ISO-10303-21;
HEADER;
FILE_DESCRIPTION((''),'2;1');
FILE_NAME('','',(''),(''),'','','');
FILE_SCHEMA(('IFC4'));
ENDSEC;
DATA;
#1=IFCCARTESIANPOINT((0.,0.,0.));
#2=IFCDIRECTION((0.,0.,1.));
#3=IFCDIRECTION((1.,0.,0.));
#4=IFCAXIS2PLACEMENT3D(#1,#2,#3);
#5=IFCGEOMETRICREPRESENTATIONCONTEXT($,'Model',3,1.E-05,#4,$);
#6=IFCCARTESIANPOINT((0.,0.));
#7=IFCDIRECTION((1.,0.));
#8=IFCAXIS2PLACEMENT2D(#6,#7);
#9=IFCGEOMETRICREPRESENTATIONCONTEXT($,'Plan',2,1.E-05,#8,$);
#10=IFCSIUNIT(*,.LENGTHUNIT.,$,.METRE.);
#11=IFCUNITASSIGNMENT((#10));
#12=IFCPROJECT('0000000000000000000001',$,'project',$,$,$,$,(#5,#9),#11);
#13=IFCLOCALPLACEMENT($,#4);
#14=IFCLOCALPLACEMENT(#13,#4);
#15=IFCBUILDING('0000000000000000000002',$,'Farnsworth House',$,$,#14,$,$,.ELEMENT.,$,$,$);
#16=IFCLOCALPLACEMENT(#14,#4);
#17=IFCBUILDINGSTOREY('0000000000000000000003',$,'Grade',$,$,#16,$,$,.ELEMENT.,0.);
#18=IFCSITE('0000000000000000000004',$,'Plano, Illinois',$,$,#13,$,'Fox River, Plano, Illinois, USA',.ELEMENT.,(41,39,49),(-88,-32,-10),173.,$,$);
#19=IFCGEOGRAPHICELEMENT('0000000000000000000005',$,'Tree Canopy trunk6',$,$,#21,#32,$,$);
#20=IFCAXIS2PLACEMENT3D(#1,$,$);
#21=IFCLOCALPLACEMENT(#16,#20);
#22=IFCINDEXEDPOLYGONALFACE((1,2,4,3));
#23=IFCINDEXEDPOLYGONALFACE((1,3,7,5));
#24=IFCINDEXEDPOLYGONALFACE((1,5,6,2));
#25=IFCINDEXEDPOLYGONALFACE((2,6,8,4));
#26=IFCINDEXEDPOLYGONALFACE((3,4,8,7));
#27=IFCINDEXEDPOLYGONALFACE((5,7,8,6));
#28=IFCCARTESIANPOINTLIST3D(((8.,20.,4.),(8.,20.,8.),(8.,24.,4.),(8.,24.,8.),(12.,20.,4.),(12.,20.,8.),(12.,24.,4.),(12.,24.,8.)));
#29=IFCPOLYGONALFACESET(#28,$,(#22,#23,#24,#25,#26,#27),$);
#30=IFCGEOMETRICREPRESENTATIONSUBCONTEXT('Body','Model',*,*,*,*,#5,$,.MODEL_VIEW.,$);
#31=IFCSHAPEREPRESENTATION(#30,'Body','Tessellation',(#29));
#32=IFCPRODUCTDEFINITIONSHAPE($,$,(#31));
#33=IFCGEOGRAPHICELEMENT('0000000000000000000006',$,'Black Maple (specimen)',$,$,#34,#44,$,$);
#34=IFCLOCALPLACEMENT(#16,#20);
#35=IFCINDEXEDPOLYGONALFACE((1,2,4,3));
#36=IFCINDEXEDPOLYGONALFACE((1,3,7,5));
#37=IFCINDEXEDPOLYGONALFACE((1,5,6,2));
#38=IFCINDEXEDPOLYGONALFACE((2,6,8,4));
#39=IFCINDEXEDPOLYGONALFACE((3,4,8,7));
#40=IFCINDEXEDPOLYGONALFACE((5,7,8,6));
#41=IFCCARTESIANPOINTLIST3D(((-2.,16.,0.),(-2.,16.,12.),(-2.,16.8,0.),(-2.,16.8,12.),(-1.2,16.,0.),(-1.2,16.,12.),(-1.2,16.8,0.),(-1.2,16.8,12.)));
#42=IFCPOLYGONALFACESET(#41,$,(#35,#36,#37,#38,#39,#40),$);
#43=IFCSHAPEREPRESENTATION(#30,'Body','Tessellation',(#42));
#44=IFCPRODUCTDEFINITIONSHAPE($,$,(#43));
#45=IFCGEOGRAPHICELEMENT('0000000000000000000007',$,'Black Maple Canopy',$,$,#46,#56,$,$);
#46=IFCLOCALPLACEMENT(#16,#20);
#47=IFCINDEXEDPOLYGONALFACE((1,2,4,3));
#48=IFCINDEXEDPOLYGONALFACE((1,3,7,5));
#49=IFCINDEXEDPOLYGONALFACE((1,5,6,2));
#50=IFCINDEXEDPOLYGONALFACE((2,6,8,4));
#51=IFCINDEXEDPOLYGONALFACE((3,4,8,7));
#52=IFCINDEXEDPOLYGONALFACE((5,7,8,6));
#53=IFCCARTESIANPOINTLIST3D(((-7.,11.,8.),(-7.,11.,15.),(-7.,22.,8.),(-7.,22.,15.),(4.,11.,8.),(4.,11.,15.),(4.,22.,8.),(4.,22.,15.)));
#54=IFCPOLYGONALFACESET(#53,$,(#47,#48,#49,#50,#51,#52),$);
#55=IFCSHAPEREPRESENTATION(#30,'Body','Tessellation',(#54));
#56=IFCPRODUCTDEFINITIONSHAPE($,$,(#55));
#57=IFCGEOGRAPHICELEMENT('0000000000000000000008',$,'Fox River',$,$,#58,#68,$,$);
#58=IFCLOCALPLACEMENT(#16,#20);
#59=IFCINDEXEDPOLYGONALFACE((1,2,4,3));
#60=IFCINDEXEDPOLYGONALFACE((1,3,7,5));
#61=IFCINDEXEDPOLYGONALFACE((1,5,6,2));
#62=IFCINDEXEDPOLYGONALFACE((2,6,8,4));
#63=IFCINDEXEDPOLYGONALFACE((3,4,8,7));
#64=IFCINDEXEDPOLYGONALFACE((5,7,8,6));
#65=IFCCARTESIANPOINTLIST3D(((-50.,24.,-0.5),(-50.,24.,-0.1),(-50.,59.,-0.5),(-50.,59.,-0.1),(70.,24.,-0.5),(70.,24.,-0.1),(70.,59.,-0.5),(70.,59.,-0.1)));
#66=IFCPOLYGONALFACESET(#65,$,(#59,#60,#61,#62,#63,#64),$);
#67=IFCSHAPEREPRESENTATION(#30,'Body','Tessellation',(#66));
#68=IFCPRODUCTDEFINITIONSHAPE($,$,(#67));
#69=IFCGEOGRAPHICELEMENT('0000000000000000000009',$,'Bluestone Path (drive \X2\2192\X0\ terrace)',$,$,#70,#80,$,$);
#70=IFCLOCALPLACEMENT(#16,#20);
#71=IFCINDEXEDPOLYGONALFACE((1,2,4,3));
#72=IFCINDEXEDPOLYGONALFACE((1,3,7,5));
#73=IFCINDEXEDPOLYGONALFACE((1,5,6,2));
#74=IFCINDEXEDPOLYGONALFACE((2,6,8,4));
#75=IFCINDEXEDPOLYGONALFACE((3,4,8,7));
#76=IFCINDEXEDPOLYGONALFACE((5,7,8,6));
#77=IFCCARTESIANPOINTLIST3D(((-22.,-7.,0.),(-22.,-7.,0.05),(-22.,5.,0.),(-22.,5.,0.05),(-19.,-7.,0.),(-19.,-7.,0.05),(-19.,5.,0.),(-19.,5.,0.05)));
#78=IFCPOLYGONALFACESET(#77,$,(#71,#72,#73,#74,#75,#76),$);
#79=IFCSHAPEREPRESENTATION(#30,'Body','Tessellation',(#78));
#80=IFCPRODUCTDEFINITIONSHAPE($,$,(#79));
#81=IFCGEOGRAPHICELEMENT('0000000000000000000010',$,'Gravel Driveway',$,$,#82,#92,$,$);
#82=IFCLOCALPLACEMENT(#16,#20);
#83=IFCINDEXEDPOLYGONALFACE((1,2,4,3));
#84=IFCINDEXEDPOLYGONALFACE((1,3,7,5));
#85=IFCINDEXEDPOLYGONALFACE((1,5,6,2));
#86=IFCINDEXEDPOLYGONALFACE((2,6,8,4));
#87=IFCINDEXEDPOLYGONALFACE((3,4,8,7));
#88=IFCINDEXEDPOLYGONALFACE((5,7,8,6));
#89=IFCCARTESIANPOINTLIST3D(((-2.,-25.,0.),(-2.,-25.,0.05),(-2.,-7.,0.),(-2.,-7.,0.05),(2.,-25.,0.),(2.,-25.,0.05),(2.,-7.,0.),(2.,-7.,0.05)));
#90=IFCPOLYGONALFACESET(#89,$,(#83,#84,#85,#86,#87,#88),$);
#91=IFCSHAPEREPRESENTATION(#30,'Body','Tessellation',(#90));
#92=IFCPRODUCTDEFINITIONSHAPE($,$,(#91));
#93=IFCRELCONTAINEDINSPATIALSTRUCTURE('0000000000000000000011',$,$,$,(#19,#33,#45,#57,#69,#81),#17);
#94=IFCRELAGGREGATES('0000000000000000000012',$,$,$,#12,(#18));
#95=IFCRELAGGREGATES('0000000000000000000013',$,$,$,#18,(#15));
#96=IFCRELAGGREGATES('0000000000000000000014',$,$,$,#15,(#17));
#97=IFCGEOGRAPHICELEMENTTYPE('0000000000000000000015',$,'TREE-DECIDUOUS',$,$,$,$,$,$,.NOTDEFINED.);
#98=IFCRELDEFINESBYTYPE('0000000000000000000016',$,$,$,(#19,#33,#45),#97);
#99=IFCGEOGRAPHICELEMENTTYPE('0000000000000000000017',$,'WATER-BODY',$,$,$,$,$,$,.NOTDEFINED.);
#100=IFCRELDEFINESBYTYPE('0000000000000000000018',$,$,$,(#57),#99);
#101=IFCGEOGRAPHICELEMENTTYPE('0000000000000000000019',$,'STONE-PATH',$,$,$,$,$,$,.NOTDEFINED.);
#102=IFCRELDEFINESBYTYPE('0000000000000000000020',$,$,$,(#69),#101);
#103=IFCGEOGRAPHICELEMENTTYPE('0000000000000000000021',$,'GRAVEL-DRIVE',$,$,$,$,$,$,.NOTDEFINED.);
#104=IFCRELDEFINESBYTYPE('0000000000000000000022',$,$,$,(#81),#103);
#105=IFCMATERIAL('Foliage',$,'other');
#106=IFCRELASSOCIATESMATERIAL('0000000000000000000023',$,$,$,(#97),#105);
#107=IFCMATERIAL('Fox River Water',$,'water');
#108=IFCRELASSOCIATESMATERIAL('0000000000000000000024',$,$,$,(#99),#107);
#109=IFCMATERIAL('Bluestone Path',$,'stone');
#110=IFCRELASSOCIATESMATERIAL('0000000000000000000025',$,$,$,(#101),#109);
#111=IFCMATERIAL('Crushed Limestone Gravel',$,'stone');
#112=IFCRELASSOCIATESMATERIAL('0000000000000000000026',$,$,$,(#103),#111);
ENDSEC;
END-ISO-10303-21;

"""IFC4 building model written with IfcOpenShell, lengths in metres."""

from ifc_helpers import new_model, si_unit, frame, origin_with_axes, origin_2d_with_axis, place, context, subcontext, project, spatial, rectangle, extrude, material, type_object, element, save


model = new_model("IFC4")

# Units and contexts
model_context = context("Model", 3, precision=1e-05, world=origin_with_axes())
plan_context = context("Plan", 2, precision=1e-05, world=origin_2d_with_axis())
body_context = subcontext(model_context, "Body", "Model", "MODEL_VIEW")
ifc_project = project(units=[si_unit("LENGTHUNIT", "METRE")], contexts=[model_context, plan_context])

# Site, building, storey
site_placement = place(None, origin_with_axes())
site = spatial("IfcSite", under=ifc_project, at=site_placement, Name="Plano, Illinois", LongName="Fox River, Plano, Illinois, USA", CompositionType="ELEMENT", RefLatitude=(41, 39, 49), RefLongitude=(-88, -32, -10), RefElevation=173.0)
building_placement = place(site_placement, origin_with_axes())
building = spatial("IfcBuilding", under=site, at=building_placement, Name="Farnsworth House", CompositionType="ELEMENT")
storey_placement = place(building_placement, origin_with_axes())
storey = spatial("IfcBuildingStorey", under=building, at=storey_placement, Name="Grade", CompositionType="ELEMENT", Elevation=0.0)

# Geographic elements
ifc_material_1 = material(Name="Foliage", Category="other")
geographic_element_type_1 = type_object("IfcGeographicElementType", Name="TREE-DECIDUOUS", PredefinedType="NOTDEFINED", material=ifc_material_1)
geographic_element_1_placement = place(storey_placement, frame((8.0, 20.0, 4.0), z_axis=(0.0, 0.0, 1.0), x_axis=(1.0, 0.0, 0.0)))
element("IfcGeographicElement", 1, at=geographic_element_1_placement, inside=storey, type_object=geographic_element_type_1, Name="Tree Canopy trunk6", context=body_context, shape_type="SweptSolid", body=[
    extrude(rectangle(XDim=4.0, YDim=4.0, at=origin_2d_with_axis()), frame((2.0, 2.0, 0.0), z_axis=(0.0, 0.0, 1.0), x_axis=(1.0, 0.0, 0.0)), (0.0, 0.0, 1.0), 4.0),
])
geographic_element_2_placement = place(storey_placement, frame((-2.0, 16.0, 0.0), z_axis=(0.0, 0.0, 1.0), x_axis=(1.0, 0.0, 0.0)))
element("IfcGeographicElement", 2, at=geographic_element_2_placement, inside=storey, type_object=geographic_element_type_1, Name="Black Maple (specimen)", context=body_context, shape_type="SweptSolid", body=[
    extrude(rectangle(XDim=0.8, YDim=0.8, at=origin_2d_with_axis()), frame((0.4, 0.4, 0.0), z_axis=(0.0, 0.0, 1.0), x_axis=(1.0, 0.0, 0.0)), (0.0, 0.0, 1.0), 12.0),
])
geographic_element_3_placement = place(storey_placement, frame((-7.0, 11.0, 8.0), z_axis=(0.0, 0.0, 1.0), x_axis=(1.0, 0.0, 0.0)))
element("IfcGeographicElement", 3, at=geographic_element_3_placement, inside=storey, type_object=geographic_element_type_1, Name="Black Maple Canopy", context=body_context, shape_type="SweptSolid", body=[
    extrude(rectangle(XDim=11.0, YDim=11.0, at=origin_2d_with_axis()), frame((5.5, 5.5, 0.0), z_axis=(0.0, 0.0, 1.0), x_axis=(1.0, 0.0, 0.0)), (0.0, 0.0, 1.0), 7.0),
])
ifc_material_2 = material(Name="Fox River Water", Category="water")
geographic_element_type_2 = type_object("IfcGeographicElementType", Name="WATER-BODY", PredefinedType="NOTDEFINED", material=ifc_material_2)
geographic_element_4_placement = place(storey_placement, frame((-50.0, 24.0, -0.5), z_axis=(0.0, 0.0, 1.0), x_axis=(1.0, 0.0, 0.0)))
element("IfcGeographicElement", 4, at=geographic_element_4_placement, inside=storey, type_object=geographic_element_type_2, Name="Fox River", context=body_context, shape_type="SweptSolid", body=[
    extrude(rectangle(XDim=120.0, YDim=35.0, at=origin_2d_with_axis()), frame((60.0, 17.5, 0.0), z_axis=(0.0, 0.0, 1.0), x_axis=(1.0, 0.0, 0.0)), (0.0, 0.0, 1.0), 0.4),
])
ifc_material_3 = material(Name="Bluestone Path", Category="stone")
geographic_element_type_3 = type_object("IfcGeographicElementType", Name="STONE-PATH", PredefinedType="NOTDEFINED", material=ifc_material_3)
geographic_element_5_placement = place(storey_placement, frame((-22.0, -7.0, 0.0), z_axis=(0.0, 0.0, 1.0), x_axis=(1.0, 0.0, 0.0)))
element("IfcGeographicElement", 5, at=geographic_element_5_placement, inside=storey, type_object=geographic_element_type_3, Name="Bluestone Path (drive → terrace)", context=body_context, shape_type="SweptSolid", body=[
    extrude(rectangle(XDim=3.0, YDim=12.0, at=origin_2d_with_axis()), frame((1.5, 6.0, 0.0), z_axis=(0.0, 0.0, 1.0), x_axis=(1.0, 0.0, 0.0)), (0.0, 0.0, 1.0), 0.05),
])
ifc_material_4 = material(Name="Crushed Limestone Gravel", Category="stone")
geographic_element_type_4 = type_object("IfcGeographicElementType", Name="GRAVEL-DRIVE", PredefinedType="NOTDEFINED", material=ifc_material_4)
geographic_element_6_placement = place(storey_placement, frame((-2.0, -25.0, 0.0), z_axis=(0.0, 0.0, 1.0), x_axis=(1.0, 0.0, 0.0)))
element("IfcGeographicElement", 6, at=geographic_element_6_placement, inside=storey, type_object=geographic_element_type_4, Name="Gravel Driveway", context=body_context, shape_type="SweptSolid", body=[
    extrude(rectangle(XDim=4.0, YDim=18.0, at=origin_2d_with_axis()), frame((2.0, 9.0, 0.0), z_axis=(0.0, 0.0, 1.0), x_axis=(1.0, 0.0, 0.0)), (0.0, 0.0, 1.0), 0.05),
])

save(model, "model.ifc")
